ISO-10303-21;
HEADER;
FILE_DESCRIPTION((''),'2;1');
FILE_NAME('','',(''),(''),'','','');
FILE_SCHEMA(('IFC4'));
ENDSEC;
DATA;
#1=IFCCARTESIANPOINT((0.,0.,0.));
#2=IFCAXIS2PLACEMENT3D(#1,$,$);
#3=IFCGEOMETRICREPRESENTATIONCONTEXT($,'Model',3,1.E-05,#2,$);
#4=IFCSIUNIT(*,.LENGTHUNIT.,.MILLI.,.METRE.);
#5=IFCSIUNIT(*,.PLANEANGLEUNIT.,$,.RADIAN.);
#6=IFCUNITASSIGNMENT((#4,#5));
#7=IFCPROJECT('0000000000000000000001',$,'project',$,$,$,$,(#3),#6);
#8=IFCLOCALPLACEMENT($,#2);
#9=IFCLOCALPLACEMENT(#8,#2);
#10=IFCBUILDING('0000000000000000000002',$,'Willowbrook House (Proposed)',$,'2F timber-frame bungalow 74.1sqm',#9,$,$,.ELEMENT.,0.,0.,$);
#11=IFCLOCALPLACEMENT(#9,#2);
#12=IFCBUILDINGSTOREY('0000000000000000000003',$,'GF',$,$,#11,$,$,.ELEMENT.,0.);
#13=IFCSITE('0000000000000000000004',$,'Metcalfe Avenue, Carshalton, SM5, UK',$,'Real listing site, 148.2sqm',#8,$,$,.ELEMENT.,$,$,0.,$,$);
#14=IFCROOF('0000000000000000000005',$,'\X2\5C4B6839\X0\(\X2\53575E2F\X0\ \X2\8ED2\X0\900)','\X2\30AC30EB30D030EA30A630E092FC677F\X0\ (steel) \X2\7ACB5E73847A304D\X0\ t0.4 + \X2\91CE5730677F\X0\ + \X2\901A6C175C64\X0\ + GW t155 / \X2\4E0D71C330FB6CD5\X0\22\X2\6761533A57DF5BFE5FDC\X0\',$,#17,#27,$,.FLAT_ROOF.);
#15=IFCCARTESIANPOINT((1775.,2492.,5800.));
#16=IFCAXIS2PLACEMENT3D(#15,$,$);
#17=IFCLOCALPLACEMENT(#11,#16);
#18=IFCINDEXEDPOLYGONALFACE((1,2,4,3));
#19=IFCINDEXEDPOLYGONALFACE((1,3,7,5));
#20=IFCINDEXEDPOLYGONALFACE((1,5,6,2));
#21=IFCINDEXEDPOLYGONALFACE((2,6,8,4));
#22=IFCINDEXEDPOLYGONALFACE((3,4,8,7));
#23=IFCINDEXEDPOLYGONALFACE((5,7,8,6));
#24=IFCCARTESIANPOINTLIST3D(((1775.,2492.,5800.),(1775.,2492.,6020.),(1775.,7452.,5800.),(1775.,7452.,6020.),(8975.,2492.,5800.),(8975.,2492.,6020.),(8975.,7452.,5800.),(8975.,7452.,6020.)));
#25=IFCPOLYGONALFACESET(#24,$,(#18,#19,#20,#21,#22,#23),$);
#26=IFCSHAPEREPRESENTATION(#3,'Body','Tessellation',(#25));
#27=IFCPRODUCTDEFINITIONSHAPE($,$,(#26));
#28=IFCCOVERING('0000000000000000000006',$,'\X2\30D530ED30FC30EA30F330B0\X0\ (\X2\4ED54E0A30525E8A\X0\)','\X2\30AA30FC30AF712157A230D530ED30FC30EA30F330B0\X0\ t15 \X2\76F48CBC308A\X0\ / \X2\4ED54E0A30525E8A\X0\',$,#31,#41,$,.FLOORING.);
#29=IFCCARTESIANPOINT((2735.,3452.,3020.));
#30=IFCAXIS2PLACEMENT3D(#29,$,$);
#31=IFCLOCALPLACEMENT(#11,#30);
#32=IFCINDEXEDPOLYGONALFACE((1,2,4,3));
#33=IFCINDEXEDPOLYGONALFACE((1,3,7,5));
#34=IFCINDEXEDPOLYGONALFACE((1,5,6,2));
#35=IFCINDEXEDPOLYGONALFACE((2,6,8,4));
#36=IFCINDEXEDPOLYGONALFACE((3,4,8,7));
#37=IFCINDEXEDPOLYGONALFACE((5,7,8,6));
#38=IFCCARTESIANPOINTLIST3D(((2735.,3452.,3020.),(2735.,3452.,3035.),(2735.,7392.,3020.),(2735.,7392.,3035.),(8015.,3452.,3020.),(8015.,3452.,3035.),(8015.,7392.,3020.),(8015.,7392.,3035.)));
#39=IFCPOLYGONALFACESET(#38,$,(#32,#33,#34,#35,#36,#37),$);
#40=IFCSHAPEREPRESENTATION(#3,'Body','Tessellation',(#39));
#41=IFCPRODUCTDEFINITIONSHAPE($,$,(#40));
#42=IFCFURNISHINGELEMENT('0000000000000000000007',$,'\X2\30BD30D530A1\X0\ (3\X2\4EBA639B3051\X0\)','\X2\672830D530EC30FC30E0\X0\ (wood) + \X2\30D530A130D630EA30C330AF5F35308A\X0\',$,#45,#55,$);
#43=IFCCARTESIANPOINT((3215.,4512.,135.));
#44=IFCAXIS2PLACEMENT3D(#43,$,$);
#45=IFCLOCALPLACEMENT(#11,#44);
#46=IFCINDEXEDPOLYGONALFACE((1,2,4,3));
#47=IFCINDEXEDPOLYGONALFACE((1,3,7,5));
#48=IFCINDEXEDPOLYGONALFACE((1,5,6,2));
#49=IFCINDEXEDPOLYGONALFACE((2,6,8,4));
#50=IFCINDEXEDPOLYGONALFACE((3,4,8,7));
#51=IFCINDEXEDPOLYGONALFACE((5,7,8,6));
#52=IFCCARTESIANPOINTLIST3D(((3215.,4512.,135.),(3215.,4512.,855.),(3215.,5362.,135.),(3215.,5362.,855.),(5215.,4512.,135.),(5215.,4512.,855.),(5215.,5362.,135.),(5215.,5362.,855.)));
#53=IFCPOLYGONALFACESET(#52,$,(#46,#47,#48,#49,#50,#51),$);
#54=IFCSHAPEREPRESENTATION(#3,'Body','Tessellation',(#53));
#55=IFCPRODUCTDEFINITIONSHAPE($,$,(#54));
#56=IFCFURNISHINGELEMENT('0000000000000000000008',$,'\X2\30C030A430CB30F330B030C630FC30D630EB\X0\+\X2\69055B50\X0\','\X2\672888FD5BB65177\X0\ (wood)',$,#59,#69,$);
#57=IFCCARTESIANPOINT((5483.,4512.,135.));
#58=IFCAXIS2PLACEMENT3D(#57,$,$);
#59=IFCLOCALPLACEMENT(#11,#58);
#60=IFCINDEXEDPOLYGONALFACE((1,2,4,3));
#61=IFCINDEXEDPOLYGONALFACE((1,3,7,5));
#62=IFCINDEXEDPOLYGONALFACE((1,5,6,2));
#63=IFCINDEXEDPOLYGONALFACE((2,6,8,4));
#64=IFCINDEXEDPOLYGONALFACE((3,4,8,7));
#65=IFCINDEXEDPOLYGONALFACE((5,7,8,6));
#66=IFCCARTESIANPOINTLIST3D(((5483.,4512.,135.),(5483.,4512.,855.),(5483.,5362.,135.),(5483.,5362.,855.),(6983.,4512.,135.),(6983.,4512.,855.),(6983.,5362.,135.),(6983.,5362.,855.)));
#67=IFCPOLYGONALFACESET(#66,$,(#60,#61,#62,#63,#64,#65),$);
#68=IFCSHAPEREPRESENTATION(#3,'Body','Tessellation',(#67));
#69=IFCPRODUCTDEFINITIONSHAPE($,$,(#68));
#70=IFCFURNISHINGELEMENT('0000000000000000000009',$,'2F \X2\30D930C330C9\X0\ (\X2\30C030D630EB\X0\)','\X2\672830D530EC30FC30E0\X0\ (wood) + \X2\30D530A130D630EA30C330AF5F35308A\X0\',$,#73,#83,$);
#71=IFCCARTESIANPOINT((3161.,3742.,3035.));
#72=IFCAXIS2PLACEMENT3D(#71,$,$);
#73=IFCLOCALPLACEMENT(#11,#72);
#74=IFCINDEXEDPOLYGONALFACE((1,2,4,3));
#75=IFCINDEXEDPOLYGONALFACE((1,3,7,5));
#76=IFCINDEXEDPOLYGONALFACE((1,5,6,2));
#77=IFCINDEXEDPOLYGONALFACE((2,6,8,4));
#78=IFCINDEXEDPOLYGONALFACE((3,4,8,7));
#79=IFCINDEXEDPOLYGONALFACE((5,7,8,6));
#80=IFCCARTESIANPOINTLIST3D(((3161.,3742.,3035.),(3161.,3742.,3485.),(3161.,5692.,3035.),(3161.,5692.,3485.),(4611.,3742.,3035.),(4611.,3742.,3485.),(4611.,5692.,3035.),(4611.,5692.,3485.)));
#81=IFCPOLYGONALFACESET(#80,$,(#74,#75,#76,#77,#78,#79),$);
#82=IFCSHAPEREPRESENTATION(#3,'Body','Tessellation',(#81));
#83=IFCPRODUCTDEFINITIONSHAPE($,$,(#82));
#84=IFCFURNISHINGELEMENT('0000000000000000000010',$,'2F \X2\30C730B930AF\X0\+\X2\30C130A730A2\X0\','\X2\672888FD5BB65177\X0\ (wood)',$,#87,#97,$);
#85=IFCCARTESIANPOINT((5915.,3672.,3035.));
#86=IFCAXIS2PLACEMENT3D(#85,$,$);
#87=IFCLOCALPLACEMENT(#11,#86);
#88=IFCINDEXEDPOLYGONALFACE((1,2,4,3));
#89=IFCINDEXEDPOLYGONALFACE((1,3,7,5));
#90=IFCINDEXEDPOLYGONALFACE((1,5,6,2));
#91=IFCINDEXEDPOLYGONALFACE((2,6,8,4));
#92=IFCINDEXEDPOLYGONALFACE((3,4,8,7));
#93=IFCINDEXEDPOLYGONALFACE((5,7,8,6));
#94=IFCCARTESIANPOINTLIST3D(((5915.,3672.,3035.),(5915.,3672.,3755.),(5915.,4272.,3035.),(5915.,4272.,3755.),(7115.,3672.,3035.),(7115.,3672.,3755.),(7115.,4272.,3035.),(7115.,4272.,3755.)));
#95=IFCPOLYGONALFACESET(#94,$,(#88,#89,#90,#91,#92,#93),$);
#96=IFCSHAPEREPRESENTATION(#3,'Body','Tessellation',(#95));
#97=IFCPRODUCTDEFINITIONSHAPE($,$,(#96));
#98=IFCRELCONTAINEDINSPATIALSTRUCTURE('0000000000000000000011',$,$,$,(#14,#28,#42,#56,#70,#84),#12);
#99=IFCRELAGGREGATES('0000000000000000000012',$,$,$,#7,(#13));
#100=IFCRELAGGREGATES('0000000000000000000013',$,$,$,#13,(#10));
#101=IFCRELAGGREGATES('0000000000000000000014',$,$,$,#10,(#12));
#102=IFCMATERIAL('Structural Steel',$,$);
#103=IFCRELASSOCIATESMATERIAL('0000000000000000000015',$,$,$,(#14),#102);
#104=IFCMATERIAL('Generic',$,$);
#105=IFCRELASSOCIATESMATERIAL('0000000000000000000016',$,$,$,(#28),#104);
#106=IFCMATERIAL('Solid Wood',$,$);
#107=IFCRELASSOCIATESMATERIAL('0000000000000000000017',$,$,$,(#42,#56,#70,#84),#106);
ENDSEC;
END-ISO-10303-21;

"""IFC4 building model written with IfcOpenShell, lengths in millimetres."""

from ifc_helpers import new_model, si_unit, frame, frame_2d, origin, place, context, project, spatial, rectangle, extrude, material, element, save


model = new_model("IFC4")

# Units and contexts
model_context = context("Model", 3, precision=1e-05, world=origin())
ifc_project = project(units=[si_unit("LENGTHUNIT", "METRE", prefix="MILLI"), si_unit("PLANEANGLEUNIT", "RADIAN")], contexts=[model_context])

# Site, building, storey
site_placement = place(None, origin())
site = spatial("IfcSite", under=ifc_project, at=site_placement, Name="Metcalfe Avenue, Carshalton, SM5, UK", ObjectType="Real listing site, 148.2sqm", CompositionType="ELEMENT", RefElevation=0.0)
building_placement = place(site_placement, origin())
building = spatial("IfcBuilding", under=site, at=building_placement, Name="Willowbrook House (Proposed)", ObjectType="2F timber-frame bungalow 74.1sqm", CompositionType="ELEMENT", ElevationOfRefHeight=0.0, ElevationOfTerrain=0.0)
storey_placement = place(building_placement, origin())
storey = spatial("IfcBuildingStorey", under=building, at=storey_placement, Name="GF", CompositionType="ELEMENT", Elevation=0.0)

# Shared definitions
ifc_material_1 = material(Name="Solid Wood")

# Roof
ifc_material_2 = material(Name="Structural Steel")
for number, where, name in (
    (1, (1775.0, 2492.0, 5800.0), "屋根(南帯 軒900)"),
):
    element("IfcRoof", number, at=place(storey_placement, frame(where)), inside=storey, material=ifc_material_2, Name=name, Description="ガルバリウム鋼板 (steel) 立平葺き t0.4 + 野地板 + 通気層 + GW t155 / 不燃・法22条区域対応", PredefinedType="FLAT_ROOF", context=model_context, shape_type="SweptSolid", body=[
        extrude(rectangle(XDim=7200.0, YDim=4960.0, at=frame_2d((3600.0, 2480.0))), frame((1775.0, 2492.0, 5800.0)), (0.0, 0.0, 1.0), 220.0),
    ])

# Covering
ifc_material_3 = material(Name="Generic")
covering_placement = place(storey_placement, frame((2735.0, 3452.0, 3020.0)))
element("IfcCovering", 2, at=covering_placement, inside=storey, material=ifc_material_3, Name="フローリング (仕上げ床)", Description="オーク無垢フローリング t15 直貼り / 仕上げ床", PredefinedType="FLOORING", context=model_context, shape_type="SweptSolid", body=[
    extrude(rectangle(XDim=5280.0, YDim=3940.0, at=frame_2d((2640.0, 1970.0))), frame((2735.0, 3452.0, 3020.0)), (0.0, 0.0, 1.0), 15.0),
])

# Furnishing elements
furnishing_1_placement = place(storey_placement, frame((3215.0, 4512.0, 135.0)))
element("IfcFurnishingElement", 3, at=furnishing_1_placement, inside=storey, material=ifc_material_1, Name="ソファ (3人掛け)", Description="木フレーム (wood) + ファブリック張り", context=model_context, shape_type="SweptSolid", body=[
    extrude(rectangle(XDim=2000.0, YDim=850.0, at=frame_2d((1000.0, 425.0))), frame((3215.0, 4512.0, 135.0)), (0.0, 0.0, 1.0), 720.0),
])
furnishing_2_placement = place(storey_placement, frame((5483.0, 4512.0, 135.0)))
element("IfcFurnishingElement", 4, at=furnishing_2_placement, inside=storey, material=ifc_material_1, Name="ダイニングテーブル+椅子", Description="木製家具 (wood)", context=model_context, shape_type="SweptSolid", body=[
    extrude(rectangle(XDim=1500.0, YDim=850.0, at=frame_2d((750.0, 425.0))), frame((5483.0, 4512.0, 135.0)), (0.0, 0.0, 1.0), 720.0),
])
furnishing_3_placement = place(storey_placement, frame((3161.0, 3742.0, 3035.0)))
element("IfcFurnishingElement", 5, at=furnishing_3_placement, inside=storey, material=ifc_material_1, Name="2F ベッド (ダブル)", Description="木フレーム (wood) + ファブリック張り", context=model_context, shape_type="SweptSolid", body=[
    extrude(rectangle(XDim=1450.0, YDim=1950.0, at=frame_2d((725.0, 975.0))), frame((3161.0, 3742.0, 3035.0)), (0.0, 0.0, 1.0), 450.0),
])
furnishing_4_placement = place(storey_placement, frame((5915.0, 3672.0, 3035.0)))
element("IfcFurnishingElement", 6, at=furnishing_4_placement, inside=storey, material=ifc_material_1, Name="2F デスク+チェア", Description="木製家具 (wood)", context=model_context, shape_type="SweptSolid", body=[
    extrude(rectangle(XDim=1200.0, YDim=600.0, at=frame_2d((600.0, 300.0))), frame((5915.0, 3672.0, 3035.0)), (0.0, 0.0, 1.0), 720.0),
])

save(model, "model.ifc")
